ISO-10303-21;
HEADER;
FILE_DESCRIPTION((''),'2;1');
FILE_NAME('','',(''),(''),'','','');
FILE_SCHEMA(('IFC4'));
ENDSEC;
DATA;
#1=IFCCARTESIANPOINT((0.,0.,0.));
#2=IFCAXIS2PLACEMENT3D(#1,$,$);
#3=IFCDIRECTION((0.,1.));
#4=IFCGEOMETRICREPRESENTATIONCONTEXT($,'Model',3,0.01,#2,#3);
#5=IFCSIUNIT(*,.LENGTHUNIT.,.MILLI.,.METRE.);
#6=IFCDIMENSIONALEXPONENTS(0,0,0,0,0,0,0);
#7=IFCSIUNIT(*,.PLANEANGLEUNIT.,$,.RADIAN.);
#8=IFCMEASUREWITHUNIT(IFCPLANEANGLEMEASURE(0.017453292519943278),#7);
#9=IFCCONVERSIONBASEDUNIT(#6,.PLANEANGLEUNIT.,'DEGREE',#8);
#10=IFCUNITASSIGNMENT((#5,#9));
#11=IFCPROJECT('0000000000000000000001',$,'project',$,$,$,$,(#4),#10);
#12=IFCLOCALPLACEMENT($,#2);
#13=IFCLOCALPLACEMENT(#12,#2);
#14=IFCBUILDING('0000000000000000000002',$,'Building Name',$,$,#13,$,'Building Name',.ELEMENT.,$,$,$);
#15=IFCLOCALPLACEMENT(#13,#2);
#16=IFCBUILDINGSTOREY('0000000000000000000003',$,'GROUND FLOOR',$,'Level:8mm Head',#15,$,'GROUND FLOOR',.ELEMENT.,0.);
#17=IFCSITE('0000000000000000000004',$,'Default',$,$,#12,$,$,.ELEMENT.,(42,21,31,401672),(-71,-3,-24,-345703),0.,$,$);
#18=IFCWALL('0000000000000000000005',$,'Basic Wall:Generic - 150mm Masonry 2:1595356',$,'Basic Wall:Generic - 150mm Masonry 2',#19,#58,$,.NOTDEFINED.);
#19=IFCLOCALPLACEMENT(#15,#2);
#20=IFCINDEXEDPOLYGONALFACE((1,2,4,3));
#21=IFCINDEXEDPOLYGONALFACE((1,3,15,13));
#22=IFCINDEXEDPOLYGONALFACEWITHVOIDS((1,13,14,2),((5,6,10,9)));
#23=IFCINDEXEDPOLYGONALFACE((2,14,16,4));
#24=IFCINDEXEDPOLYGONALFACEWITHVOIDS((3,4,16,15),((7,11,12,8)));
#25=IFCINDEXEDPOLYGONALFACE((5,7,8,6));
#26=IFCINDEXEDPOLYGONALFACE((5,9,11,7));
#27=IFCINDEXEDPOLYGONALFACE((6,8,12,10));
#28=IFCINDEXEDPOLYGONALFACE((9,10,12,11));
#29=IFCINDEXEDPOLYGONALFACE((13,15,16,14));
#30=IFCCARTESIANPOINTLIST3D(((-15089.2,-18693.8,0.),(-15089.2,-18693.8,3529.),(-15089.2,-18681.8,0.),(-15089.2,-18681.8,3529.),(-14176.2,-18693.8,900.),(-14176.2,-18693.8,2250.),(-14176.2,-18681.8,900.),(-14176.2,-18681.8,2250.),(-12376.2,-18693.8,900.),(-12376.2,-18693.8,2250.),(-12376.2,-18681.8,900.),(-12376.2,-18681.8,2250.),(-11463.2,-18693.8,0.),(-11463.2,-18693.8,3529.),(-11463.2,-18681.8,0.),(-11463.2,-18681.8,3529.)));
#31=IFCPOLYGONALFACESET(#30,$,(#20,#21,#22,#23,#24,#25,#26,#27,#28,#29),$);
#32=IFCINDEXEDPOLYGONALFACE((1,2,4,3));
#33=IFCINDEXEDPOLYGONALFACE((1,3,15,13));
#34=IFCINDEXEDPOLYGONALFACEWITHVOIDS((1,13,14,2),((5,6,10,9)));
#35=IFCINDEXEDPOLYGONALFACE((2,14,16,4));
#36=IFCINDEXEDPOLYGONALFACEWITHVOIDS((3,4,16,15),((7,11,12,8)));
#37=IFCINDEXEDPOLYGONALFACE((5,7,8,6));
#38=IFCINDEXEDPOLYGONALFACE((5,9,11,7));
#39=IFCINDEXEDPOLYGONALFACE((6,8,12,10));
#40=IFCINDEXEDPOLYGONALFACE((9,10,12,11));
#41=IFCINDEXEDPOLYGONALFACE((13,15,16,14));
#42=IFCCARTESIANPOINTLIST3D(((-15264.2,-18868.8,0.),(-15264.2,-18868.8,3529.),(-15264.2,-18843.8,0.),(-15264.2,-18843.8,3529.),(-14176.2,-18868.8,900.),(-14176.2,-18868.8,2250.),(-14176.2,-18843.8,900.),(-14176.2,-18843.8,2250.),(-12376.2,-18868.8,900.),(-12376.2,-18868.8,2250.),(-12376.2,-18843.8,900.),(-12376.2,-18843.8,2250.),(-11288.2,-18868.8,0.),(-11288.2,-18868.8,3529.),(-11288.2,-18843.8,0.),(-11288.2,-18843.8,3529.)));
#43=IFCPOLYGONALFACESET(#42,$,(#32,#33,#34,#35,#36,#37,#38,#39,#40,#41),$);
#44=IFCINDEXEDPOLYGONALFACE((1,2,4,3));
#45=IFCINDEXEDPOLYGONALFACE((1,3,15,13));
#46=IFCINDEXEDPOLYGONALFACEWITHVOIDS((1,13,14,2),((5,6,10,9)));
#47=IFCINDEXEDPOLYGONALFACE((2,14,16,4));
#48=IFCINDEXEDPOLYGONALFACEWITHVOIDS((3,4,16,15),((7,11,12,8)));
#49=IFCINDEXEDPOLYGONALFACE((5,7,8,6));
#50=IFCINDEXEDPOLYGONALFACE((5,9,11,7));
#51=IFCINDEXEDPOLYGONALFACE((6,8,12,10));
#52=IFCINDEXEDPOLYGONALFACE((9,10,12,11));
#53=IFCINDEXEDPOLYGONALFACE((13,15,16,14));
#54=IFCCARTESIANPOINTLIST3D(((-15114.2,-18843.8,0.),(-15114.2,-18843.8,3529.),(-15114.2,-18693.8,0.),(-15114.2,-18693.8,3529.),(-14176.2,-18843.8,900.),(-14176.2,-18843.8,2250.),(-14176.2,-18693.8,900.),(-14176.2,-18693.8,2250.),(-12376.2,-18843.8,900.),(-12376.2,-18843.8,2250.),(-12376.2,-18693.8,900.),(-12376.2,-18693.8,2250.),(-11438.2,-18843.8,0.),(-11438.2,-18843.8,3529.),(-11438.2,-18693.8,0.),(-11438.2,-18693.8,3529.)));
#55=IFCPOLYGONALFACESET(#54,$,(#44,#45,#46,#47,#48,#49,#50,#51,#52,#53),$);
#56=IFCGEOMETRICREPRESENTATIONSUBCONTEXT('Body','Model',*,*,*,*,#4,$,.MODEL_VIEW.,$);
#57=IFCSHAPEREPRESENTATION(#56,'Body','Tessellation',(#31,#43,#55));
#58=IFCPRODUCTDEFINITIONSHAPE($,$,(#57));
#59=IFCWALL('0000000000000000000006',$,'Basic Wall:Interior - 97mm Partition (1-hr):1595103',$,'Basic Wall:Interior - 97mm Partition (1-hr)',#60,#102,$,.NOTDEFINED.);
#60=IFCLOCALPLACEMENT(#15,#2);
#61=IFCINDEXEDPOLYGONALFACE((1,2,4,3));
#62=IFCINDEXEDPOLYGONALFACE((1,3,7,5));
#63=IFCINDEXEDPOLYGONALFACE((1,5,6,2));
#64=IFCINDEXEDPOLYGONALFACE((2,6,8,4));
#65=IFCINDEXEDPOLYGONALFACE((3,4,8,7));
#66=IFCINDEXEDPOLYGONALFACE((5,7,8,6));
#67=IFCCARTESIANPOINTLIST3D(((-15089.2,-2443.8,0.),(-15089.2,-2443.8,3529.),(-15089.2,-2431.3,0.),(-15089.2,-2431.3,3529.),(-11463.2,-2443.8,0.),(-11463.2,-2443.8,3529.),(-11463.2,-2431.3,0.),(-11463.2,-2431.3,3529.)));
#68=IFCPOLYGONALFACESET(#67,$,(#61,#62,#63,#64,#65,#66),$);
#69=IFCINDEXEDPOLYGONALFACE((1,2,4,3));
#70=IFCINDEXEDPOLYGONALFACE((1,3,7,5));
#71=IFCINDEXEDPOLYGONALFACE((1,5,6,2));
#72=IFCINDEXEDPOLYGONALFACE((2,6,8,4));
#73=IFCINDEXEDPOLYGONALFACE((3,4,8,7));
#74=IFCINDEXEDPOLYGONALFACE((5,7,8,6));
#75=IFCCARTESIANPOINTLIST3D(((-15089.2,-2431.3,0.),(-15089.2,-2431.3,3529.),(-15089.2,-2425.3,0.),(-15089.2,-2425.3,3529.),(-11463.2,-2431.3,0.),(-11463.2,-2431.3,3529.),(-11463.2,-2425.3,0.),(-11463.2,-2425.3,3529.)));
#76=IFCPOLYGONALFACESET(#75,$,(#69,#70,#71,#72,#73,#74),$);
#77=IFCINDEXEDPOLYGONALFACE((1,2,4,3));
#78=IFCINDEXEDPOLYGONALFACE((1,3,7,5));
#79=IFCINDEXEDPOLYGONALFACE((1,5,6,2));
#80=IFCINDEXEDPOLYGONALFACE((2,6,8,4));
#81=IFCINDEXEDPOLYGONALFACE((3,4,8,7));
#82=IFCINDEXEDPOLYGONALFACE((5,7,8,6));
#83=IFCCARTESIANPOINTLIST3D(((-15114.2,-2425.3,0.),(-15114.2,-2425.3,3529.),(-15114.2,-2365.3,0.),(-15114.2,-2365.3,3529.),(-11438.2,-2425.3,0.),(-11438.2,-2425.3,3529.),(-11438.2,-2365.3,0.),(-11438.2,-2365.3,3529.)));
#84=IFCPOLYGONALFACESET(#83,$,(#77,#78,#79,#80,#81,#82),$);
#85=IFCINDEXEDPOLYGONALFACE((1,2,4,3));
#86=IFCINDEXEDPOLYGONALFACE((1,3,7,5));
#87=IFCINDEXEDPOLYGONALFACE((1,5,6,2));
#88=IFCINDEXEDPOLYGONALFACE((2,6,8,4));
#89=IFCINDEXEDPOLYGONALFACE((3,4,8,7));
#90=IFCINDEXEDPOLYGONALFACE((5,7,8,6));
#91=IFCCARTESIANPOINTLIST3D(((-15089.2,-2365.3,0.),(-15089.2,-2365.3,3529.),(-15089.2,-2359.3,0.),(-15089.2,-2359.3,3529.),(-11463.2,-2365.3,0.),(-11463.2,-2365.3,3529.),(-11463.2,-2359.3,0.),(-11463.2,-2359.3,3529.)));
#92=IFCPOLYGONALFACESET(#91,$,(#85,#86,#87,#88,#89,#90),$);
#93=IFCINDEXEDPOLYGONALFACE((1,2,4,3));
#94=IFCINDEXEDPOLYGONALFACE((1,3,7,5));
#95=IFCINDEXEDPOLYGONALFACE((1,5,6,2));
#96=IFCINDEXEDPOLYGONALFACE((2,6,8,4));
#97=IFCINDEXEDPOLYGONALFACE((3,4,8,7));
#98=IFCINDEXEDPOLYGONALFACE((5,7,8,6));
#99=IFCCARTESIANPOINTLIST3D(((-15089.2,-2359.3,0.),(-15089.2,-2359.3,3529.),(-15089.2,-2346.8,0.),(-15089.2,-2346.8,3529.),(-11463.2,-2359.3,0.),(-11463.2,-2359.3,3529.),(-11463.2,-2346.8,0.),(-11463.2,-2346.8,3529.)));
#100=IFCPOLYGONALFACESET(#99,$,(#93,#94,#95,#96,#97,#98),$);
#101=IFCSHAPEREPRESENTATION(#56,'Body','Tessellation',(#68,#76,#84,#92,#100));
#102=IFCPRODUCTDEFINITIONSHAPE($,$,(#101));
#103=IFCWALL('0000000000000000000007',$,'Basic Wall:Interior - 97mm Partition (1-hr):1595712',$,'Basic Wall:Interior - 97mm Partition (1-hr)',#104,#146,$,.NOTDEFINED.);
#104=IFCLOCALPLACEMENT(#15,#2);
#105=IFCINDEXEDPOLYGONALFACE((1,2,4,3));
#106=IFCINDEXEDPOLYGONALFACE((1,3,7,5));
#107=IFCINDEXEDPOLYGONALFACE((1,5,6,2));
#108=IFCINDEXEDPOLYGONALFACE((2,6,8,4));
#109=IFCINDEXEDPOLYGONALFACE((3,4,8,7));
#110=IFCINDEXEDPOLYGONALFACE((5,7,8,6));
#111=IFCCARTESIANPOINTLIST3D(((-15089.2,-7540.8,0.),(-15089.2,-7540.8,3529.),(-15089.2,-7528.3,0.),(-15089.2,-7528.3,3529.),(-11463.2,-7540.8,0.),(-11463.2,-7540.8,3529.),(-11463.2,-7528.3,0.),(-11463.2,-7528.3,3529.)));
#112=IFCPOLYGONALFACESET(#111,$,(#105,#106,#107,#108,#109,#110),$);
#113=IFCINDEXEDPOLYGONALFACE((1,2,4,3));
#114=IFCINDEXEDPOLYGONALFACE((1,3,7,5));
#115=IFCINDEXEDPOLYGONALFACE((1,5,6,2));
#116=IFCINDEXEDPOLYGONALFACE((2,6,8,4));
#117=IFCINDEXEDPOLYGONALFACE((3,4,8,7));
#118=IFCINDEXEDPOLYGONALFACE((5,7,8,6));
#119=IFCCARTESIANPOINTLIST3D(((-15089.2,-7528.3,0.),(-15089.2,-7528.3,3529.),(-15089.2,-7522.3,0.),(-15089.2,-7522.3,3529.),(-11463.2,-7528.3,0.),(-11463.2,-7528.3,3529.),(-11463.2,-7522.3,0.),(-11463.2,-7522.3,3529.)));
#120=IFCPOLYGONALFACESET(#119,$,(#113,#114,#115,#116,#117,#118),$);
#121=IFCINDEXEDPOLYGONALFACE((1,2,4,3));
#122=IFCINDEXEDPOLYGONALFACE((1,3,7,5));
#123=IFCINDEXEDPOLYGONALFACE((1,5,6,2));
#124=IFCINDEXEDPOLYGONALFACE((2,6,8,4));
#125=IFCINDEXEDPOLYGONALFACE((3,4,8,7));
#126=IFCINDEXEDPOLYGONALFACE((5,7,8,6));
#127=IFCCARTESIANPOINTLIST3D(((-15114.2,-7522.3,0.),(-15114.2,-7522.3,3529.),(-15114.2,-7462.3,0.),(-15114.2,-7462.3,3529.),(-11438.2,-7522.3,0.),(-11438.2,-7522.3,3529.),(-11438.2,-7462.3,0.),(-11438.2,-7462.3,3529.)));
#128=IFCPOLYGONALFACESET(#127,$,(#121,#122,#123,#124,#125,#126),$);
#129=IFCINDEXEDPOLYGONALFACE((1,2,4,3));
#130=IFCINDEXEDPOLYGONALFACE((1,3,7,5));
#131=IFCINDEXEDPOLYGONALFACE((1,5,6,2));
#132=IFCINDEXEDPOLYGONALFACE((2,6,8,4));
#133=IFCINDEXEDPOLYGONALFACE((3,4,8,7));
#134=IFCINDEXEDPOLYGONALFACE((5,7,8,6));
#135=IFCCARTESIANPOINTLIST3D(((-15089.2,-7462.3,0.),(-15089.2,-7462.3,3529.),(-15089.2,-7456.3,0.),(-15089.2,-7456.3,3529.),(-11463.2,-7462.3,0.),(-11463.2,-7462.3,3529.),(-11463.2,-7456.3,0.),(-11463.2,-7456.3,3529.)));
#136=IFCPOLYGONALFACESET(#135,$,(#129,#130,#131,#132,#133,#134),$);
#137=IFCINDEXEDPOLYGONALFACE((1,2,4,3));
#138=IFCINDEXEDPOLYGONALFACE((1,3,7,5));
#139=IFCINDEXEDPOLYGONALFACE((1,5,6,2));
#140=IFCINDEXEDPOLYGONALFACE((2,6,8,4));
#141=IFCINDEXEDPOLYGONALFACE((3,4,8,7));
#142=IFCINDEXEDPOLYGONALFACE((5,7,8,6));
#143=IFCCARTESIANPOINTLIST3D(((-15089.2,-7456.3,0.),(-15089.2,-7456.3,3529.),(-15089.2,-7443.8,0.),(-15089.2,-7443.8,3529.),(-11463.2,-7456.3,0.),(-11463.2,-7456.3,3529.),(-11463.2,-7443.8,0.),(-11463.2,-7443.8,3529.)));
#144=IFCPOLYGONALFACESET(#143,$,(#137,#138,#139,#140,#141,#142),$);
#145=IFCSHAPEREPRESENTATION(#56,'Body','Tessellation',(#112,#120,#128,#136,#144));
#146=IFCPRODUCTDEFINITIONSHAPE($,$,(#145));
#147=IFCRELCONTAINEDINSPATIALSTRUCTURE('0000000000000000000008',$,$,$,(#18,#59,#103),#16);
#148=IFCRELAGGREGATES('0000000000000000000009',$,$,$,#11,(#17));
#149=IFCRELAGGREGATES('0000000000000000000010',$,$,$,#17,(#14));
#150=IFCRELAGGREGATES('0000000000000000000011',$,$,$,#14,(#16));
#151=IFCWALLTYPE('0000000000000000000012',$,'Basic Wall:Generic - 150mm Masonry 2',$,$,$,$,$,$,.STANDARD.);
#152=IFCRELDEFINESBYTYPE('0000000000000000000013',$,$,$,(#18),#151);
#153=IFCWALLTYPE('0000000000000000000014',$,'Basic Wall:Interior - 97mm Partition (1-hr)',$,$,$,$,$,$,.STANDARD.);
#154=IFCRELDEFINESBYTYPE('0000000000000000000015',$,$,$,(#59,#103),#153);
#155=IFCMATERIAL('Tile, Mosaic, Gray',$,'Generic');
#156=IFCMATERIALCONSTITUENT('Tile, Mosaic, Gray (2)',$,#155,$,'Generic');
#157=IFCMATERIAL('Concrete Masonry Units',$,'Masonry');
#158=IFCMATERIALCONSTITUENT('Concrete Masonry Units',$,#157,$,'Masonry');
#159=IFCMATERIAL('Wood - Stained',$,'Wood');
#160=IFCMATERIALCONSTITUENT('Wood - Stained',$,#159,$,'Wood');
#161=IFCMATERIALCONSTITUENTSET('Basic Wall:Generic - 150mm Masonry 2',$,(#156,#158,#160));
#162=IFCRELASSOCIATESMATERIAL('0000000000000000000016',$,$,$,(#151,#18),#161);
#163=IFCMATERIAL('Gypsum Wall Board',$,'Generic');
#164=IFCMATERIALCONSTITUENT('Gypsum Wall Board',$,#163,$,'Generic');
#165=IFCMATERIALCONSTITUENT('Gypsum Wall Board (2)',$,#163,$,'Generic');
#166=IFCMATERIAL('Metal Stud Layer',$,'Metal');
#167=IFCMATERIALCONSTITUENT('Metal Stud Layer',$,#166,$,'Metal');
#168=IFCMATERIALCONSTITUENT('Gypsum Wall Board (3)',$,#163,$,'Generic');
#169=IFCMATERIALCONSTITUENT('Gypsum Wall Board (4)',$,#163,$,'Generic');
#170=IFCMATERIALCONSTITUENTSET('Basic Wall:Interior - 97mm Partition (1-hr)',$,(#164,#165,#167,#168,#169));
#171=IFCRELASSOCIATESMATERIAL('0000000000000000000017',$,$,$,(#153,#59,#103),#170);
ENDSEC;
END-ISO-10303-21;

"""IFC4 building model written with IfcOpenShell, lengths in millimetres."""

from ifc_helpers import new_model, entity, si_unit, converted_unit, direction, frame, origin, place, context, subcontext, project, spatial, indexed_curve, outline, extrude, material, constituent, constituent_set, type_object, element, save


model = new_model("IFC4")

# Units and contexts
model_context = context("Model", 3, precision=0.01, world=origin(), true_north=direction((0.0, 1.0)))
body_context = subcontext(model_context, "Body", "Model", "MODEL_VIEW")
ifc_project = project(units=[si_unit("LENGTHUNIT", "METRE", prefix="MILLI"), converted_unit("PLANEANGLEUNIT", "DEGREE", entity("IfcPlaneAngleMeasure", 0.017453292519943278), si_unit("PLANEANGLEUNIT", "RADIAN"), dimensions=[0, 0, 0, 0, 0, 0, 0])], contexts=[model_context])

# Site, building, storey
site_placement = place(None, origin())
site = spatial("IfcSite", under=ifc_project, at=site_placement, Name="Default", CompositionType="ELEMENT", RefLatitude=(42, 21, 31, 401672), RefLongitude=(-71, -3, -24, -345703), RefElevation=0.0)
building_placement = place(site_placement, origin())
building = spatial("IfcBuilding", under=site, at=building_placement, Name="Building Name", LongName="Building Name", CompositionType="ELEMENT")
storey_placement = place(building_placement, origin())
storey = spatial("IfcBuildingStorey", under=building, at=storey_placement, Name="GROUND FLOOR", ObjectType="Level:8mm Head", LongName="GROUND FLOOR", CompositionType="ELEMENT", Elevation=0.0)

# Shared definitions
ifc_material_1 = material(Name="Tile, Mosaic, Gray", Category="Generic")
ifc_constituent_1 = constituent(ifc_material_1, Name="Tile, Mosaic, Gray (2)", Category="Generic")
ifc_material_2 = material(Name="Concrete Masonry Units", Category="Masonry")
ifc_constituent_2 = constituent(ifc_material_2, Name="Concrete Masonry Units", Category="Masonry")
ifc_material_3 = material(Name="Wood - Stained", Category="Wood")
ifc_constituent_3 = constituent(ifc_material_3, Name="Wood - Stained", Category="Wood")
ifc_constituent_set_1 = constituent_set(constituents=[ifc_constituent_1, ifc_constituent_2, ifc_constituent_3], Name="Basic Wall:Generic - 150mm Masonry 2")
wall_type_1 = type_object("IfcWallType", Name="Basic Wall:Generic - 150mm Masonry 2", PredefinedType="STANDARD", material=ifc_constituent_set_1)

# Wall, opening
wall_1_placement = place(storey_placement, frame((-11463.2, -18775.3, 0.0), z_axis=(0.0, 0.0, 1.0), x_axis=(-1.0, 0.0, 0.0)))
wall_1 = element("IfcWall", 1, at=wall_1_placement, inside=storey, type_object=wall_type_1, material=ifc_constituent_set_1, Name="Basic Wall:Generic - 150mm Masonry 2:1595356", ObjectType="Basic Wall:Generic - 150mm Masonry 2", PredefinedType="NOTDEFINED", context=body_context, shape_type="SweptSolid", body=[
    extrude(outline(indexed_curve([(-1764.5, -1813.0), (1764.5, -1813.0), (1764.5, 1813.0), (-1764.5, 1813.0), (-1764.5, -1813.0)], self_intersect=False), holes=[indexed_curve([(-864.5, -900.0), (-864.5, 900.0), (485.5, 900.0), (485.5, -900.0), (-864.5, -900.0)], self_intersect=False)]), frame((1813.0, -81.5, 1764.5), z_axis=(0.0, -1.0, 0.0), x_axis=(0.0, 0.0, 1.0)), (0.0, 0.0, 1.0), 12.0),
    extrude(outline(indexed_curve([(-1988.0, -1764.5), (1988.0, -1764.5), (1988.0, 1764.5), (-1988.0, 1764.5), (-1988.0, -1764.5)], self_intersect=False), holes=[indexed_curve([(900.0, 485.5), (900.0, -864.5), (-900.0, -864.5), (-900.0, 485.5), (900.0, 485.5)], self_intersect=False)]), frame((1813.0, 93.5, 1764.5), z_axis=(0.0, -1.0, 0.0), x_axis=(1.0, 0.0, 0.0)), (0.0, 0.0, 1.0), 25.0),
    extrude(outline(indexed_curve([(-1764.5, -1838.0), (1764.5, -1838.0), (1764.5, 1838.0), (-1764.5, 1838.0), (-1764.5, -1838.0)], self_intersect=False), holes=[indexed_curve([(-864.5, -900.0), (-864.5, 900.0), (485.5, 900.0), (485.5, -900.0), (-864.5, -900.0)], self_intersect=False)]), frame((1813.0, 68.5, 1764.5), z_axis=(0.0, -1.0, 0.0), x_axis=(0.0, 0.0, 1.0)), (0.0, 0.0, 1.0), 150.0),
])
opening_placement = place(wall_1_placement, frame((913.0, -93.5, 900.0)))
element("IfcOpeningElement", 2, at=opening_placement, cuts=wall_1, PredefinedType="OPENING", context=body_context, shape_type="SweptSolid", body=[
    extrude(outline(indexed_curve([(1350.0, 1800.0), (0.0, 1800.0), (0.0, 0.0), (1350.0, 0.0), (1350.0, 1800.0)], self_intersect=False)), frame((0.0, 0.0, 0.0), z_axis=(0.0, 1.0, 0.0), x_axis=(0.0, 0.0, 1.0)), (0.0, 0.0, 1.0), 187.0),
])

# Walls
ifc_material_4 = material(Name="Gypsum Wall Board", Category="Generic")
ifc_constituent_4 = constituent(ifc_material_4, Name="Gypsum Wall Board", Category="Generic")
ifc_constituent_5 = constituent(ifc_material_4, Name="Gypsum Wall Board (2)", Category="Generic")
ifc_material_5 = material(Name="Metal Stud Layer", Category="Metal")
ifc_constituent_6 = constituent(ifc_material_5, Name="Metal Stud Layer", Category="Metal")
ifc_constituent_7 = constituent(ifc_material_4, Name="Gypsum Wall Board (3)", Category="Generic")
ifc_constituent_8 = constituent(ifc_material_4, Name="Gypsum Wall Board (4)", Category="Generic")
ifc_constituent_set_2 = constituent_set(constituents=[ifc_constituent_4, ifc_constituent_5, ifc_constituent_6, ifc_constituent_7, ifc_constituent_8], Name="Basic Wall:Interior - 97mm Partition (1-hr)")
wall_type_2 = type_object("IfcWallType", Name="Basic Wall:Interior - 97mm Partition (1-hr)", PredefinedType="STANDARD", material=ifc_constituent_set_2)
wall_2_placement = place(storey_placement, frame((-15089.2, -2395.3, 0.0)))
element("IfcWall", 3, at=wall_2_placement, inside=storey, type_object=wall_type_2, material=ifc_constituent_set_2, Name="Basic Wall:Interior - 97mm Partition (1-hr):1595103", ObjectType="Basic Wall:Interior - 97mm Partition (1-hr)", PredefinedType="NOTDEFINED", context=body_context, shape_type="SweptSolid", body=[
    extrude(outline(indexed_curve([(-6.3, -1813.0), (6.2, -1813.0), (6.3, 1813.0), (-6.2, 1813.0), (-6.3, -1813.0)], self_intersect=False)), frame((1813.0, -42.2, 0.0), z_axis=(0.0, 0.0, 1.0), x_axis=(0.0, 1.0, 0.0)), (0.0, 0.0, 1.0), 3529.0),
    extrude(outline(indexed_curve([(-1813.0, -3.0), (1813.0, -3.0), (1813.0, 3.0), (-1813.0, 3.0), (-1813.0, -3.0)], self_intersect=False)), frame((1813.0, -33.0, 0.0)), (0.0, 0.0, 1.0), 3529.0),
    extrude(outline(indexed_curve([(-1838.0, -30.0), (1838.0, -30.0), (1838.0, 30.0), (-1838.0, 30.0), (-1838.0, -30.0)], self_intersect=False)), frame((1813.0, 0.0, 0.0)), (0.0, 0.0, 1.0), 3529.0),
    extrude(outline(indexed_curve([(-1813.0, -3.0), (1813.0, -3.0), (1813.0, 3.0), (-1813.0, 3.0), (-1813.0, -3.0)], self_intersect=False)), frame((1813.0, 33.0, 0.0)), (0.0, 0.0, 1.0), 3529.0),
    extrude(outline(indexed_curve([(-6.3, -1813.0), (6.2, -1813.0), (6.3, 1813.0), (-6.2, 1813.0), (-6.3, -1813.0)], self_intersect=False)), frame((1813.0, 42.3, 0.0), z_axis=(0.0, 0.0, 1.0), x_axis=(0.0, -1.0, 0.0)), (0.0, 0.0, 1.0), 3529.0),
])
wall_3_placement = place(storey_placement, frame((-15089.2, -7492.3, 0.0)))
element("IfcWall", 4, at=wall_3_placement, inside=storey, type_object=wall_type_2, material=ifc_constituent_set_2, Name="Basic Wall:Interior - 97mm Partition (1-hr):1595712", ObjectType="Basic Wall:Interior - 97mm Partition (1-hr)", PredefinedType="NOTDEFINED", context=body_context, shape_type="SweptSolid", body=[
    extrude(outline(indexed_curve([(-6.3, -1813.0), (6.2, -1813.0), (6.3, 1813.0), (-6.2, 1813.0), (-6.3, -1813.0)], self_intersect=False)), frame((1813.0, -42.2, 0.0), z_axis=(0.0, 0.0, 1.0), x_axis=(0.0, 1.0, 0.0)), (0.0, 0.0, 1.0), 3529.0),
    extrude(outline(indexed_curve([(-1813.0, -3.0), (1813.0, -3.0), (1813.0, 3.0), (-1813.0, 3.0), (-1813.0, -3.0)], self_intersect=False)), frame((1813.0, -33.0, 0.0)), (0.0, 0.0, 1.0), 3529.0),
    extrude(outline(indexed_curve([(-1838.0, -30.0), (1838.0, -30.0), (1838.0, 30.0), (-1838.0, 30.0), (-1838.0, -30.0)], self_intersect=False)), frame((1813.0, 0.0, 0.0)), (0.0, 0.0, 1.0), 3529.0),
    extrude(outline(indexed_curve([(-1813.0, -3.0), (1813.0, -3.0), (1813.0, 3.0), (-1813.0, 3.0), (-1813.0, -3.0)], self_intersect=False)), frame((1813.0, 33.0, 0.0)), (0.0, 0.0, 1.0), 3529.0),
    extrude(outline(indexed_curve([(-6.3, -1813.0), (6.2, -1813.0), (6.3, 1813.0), (-6.2, 1813.0), (-6.3, -1813.0)], self_intersect=False)), frame((1813.0, 42.3, 0.0), z_axis=(0.0, 0.0, 1.0), x_axis=(0.0, -1.0, 0.0)), (0.0, 0.0, 1.0), 3529.0),
])

save(model, "model.ifc")
